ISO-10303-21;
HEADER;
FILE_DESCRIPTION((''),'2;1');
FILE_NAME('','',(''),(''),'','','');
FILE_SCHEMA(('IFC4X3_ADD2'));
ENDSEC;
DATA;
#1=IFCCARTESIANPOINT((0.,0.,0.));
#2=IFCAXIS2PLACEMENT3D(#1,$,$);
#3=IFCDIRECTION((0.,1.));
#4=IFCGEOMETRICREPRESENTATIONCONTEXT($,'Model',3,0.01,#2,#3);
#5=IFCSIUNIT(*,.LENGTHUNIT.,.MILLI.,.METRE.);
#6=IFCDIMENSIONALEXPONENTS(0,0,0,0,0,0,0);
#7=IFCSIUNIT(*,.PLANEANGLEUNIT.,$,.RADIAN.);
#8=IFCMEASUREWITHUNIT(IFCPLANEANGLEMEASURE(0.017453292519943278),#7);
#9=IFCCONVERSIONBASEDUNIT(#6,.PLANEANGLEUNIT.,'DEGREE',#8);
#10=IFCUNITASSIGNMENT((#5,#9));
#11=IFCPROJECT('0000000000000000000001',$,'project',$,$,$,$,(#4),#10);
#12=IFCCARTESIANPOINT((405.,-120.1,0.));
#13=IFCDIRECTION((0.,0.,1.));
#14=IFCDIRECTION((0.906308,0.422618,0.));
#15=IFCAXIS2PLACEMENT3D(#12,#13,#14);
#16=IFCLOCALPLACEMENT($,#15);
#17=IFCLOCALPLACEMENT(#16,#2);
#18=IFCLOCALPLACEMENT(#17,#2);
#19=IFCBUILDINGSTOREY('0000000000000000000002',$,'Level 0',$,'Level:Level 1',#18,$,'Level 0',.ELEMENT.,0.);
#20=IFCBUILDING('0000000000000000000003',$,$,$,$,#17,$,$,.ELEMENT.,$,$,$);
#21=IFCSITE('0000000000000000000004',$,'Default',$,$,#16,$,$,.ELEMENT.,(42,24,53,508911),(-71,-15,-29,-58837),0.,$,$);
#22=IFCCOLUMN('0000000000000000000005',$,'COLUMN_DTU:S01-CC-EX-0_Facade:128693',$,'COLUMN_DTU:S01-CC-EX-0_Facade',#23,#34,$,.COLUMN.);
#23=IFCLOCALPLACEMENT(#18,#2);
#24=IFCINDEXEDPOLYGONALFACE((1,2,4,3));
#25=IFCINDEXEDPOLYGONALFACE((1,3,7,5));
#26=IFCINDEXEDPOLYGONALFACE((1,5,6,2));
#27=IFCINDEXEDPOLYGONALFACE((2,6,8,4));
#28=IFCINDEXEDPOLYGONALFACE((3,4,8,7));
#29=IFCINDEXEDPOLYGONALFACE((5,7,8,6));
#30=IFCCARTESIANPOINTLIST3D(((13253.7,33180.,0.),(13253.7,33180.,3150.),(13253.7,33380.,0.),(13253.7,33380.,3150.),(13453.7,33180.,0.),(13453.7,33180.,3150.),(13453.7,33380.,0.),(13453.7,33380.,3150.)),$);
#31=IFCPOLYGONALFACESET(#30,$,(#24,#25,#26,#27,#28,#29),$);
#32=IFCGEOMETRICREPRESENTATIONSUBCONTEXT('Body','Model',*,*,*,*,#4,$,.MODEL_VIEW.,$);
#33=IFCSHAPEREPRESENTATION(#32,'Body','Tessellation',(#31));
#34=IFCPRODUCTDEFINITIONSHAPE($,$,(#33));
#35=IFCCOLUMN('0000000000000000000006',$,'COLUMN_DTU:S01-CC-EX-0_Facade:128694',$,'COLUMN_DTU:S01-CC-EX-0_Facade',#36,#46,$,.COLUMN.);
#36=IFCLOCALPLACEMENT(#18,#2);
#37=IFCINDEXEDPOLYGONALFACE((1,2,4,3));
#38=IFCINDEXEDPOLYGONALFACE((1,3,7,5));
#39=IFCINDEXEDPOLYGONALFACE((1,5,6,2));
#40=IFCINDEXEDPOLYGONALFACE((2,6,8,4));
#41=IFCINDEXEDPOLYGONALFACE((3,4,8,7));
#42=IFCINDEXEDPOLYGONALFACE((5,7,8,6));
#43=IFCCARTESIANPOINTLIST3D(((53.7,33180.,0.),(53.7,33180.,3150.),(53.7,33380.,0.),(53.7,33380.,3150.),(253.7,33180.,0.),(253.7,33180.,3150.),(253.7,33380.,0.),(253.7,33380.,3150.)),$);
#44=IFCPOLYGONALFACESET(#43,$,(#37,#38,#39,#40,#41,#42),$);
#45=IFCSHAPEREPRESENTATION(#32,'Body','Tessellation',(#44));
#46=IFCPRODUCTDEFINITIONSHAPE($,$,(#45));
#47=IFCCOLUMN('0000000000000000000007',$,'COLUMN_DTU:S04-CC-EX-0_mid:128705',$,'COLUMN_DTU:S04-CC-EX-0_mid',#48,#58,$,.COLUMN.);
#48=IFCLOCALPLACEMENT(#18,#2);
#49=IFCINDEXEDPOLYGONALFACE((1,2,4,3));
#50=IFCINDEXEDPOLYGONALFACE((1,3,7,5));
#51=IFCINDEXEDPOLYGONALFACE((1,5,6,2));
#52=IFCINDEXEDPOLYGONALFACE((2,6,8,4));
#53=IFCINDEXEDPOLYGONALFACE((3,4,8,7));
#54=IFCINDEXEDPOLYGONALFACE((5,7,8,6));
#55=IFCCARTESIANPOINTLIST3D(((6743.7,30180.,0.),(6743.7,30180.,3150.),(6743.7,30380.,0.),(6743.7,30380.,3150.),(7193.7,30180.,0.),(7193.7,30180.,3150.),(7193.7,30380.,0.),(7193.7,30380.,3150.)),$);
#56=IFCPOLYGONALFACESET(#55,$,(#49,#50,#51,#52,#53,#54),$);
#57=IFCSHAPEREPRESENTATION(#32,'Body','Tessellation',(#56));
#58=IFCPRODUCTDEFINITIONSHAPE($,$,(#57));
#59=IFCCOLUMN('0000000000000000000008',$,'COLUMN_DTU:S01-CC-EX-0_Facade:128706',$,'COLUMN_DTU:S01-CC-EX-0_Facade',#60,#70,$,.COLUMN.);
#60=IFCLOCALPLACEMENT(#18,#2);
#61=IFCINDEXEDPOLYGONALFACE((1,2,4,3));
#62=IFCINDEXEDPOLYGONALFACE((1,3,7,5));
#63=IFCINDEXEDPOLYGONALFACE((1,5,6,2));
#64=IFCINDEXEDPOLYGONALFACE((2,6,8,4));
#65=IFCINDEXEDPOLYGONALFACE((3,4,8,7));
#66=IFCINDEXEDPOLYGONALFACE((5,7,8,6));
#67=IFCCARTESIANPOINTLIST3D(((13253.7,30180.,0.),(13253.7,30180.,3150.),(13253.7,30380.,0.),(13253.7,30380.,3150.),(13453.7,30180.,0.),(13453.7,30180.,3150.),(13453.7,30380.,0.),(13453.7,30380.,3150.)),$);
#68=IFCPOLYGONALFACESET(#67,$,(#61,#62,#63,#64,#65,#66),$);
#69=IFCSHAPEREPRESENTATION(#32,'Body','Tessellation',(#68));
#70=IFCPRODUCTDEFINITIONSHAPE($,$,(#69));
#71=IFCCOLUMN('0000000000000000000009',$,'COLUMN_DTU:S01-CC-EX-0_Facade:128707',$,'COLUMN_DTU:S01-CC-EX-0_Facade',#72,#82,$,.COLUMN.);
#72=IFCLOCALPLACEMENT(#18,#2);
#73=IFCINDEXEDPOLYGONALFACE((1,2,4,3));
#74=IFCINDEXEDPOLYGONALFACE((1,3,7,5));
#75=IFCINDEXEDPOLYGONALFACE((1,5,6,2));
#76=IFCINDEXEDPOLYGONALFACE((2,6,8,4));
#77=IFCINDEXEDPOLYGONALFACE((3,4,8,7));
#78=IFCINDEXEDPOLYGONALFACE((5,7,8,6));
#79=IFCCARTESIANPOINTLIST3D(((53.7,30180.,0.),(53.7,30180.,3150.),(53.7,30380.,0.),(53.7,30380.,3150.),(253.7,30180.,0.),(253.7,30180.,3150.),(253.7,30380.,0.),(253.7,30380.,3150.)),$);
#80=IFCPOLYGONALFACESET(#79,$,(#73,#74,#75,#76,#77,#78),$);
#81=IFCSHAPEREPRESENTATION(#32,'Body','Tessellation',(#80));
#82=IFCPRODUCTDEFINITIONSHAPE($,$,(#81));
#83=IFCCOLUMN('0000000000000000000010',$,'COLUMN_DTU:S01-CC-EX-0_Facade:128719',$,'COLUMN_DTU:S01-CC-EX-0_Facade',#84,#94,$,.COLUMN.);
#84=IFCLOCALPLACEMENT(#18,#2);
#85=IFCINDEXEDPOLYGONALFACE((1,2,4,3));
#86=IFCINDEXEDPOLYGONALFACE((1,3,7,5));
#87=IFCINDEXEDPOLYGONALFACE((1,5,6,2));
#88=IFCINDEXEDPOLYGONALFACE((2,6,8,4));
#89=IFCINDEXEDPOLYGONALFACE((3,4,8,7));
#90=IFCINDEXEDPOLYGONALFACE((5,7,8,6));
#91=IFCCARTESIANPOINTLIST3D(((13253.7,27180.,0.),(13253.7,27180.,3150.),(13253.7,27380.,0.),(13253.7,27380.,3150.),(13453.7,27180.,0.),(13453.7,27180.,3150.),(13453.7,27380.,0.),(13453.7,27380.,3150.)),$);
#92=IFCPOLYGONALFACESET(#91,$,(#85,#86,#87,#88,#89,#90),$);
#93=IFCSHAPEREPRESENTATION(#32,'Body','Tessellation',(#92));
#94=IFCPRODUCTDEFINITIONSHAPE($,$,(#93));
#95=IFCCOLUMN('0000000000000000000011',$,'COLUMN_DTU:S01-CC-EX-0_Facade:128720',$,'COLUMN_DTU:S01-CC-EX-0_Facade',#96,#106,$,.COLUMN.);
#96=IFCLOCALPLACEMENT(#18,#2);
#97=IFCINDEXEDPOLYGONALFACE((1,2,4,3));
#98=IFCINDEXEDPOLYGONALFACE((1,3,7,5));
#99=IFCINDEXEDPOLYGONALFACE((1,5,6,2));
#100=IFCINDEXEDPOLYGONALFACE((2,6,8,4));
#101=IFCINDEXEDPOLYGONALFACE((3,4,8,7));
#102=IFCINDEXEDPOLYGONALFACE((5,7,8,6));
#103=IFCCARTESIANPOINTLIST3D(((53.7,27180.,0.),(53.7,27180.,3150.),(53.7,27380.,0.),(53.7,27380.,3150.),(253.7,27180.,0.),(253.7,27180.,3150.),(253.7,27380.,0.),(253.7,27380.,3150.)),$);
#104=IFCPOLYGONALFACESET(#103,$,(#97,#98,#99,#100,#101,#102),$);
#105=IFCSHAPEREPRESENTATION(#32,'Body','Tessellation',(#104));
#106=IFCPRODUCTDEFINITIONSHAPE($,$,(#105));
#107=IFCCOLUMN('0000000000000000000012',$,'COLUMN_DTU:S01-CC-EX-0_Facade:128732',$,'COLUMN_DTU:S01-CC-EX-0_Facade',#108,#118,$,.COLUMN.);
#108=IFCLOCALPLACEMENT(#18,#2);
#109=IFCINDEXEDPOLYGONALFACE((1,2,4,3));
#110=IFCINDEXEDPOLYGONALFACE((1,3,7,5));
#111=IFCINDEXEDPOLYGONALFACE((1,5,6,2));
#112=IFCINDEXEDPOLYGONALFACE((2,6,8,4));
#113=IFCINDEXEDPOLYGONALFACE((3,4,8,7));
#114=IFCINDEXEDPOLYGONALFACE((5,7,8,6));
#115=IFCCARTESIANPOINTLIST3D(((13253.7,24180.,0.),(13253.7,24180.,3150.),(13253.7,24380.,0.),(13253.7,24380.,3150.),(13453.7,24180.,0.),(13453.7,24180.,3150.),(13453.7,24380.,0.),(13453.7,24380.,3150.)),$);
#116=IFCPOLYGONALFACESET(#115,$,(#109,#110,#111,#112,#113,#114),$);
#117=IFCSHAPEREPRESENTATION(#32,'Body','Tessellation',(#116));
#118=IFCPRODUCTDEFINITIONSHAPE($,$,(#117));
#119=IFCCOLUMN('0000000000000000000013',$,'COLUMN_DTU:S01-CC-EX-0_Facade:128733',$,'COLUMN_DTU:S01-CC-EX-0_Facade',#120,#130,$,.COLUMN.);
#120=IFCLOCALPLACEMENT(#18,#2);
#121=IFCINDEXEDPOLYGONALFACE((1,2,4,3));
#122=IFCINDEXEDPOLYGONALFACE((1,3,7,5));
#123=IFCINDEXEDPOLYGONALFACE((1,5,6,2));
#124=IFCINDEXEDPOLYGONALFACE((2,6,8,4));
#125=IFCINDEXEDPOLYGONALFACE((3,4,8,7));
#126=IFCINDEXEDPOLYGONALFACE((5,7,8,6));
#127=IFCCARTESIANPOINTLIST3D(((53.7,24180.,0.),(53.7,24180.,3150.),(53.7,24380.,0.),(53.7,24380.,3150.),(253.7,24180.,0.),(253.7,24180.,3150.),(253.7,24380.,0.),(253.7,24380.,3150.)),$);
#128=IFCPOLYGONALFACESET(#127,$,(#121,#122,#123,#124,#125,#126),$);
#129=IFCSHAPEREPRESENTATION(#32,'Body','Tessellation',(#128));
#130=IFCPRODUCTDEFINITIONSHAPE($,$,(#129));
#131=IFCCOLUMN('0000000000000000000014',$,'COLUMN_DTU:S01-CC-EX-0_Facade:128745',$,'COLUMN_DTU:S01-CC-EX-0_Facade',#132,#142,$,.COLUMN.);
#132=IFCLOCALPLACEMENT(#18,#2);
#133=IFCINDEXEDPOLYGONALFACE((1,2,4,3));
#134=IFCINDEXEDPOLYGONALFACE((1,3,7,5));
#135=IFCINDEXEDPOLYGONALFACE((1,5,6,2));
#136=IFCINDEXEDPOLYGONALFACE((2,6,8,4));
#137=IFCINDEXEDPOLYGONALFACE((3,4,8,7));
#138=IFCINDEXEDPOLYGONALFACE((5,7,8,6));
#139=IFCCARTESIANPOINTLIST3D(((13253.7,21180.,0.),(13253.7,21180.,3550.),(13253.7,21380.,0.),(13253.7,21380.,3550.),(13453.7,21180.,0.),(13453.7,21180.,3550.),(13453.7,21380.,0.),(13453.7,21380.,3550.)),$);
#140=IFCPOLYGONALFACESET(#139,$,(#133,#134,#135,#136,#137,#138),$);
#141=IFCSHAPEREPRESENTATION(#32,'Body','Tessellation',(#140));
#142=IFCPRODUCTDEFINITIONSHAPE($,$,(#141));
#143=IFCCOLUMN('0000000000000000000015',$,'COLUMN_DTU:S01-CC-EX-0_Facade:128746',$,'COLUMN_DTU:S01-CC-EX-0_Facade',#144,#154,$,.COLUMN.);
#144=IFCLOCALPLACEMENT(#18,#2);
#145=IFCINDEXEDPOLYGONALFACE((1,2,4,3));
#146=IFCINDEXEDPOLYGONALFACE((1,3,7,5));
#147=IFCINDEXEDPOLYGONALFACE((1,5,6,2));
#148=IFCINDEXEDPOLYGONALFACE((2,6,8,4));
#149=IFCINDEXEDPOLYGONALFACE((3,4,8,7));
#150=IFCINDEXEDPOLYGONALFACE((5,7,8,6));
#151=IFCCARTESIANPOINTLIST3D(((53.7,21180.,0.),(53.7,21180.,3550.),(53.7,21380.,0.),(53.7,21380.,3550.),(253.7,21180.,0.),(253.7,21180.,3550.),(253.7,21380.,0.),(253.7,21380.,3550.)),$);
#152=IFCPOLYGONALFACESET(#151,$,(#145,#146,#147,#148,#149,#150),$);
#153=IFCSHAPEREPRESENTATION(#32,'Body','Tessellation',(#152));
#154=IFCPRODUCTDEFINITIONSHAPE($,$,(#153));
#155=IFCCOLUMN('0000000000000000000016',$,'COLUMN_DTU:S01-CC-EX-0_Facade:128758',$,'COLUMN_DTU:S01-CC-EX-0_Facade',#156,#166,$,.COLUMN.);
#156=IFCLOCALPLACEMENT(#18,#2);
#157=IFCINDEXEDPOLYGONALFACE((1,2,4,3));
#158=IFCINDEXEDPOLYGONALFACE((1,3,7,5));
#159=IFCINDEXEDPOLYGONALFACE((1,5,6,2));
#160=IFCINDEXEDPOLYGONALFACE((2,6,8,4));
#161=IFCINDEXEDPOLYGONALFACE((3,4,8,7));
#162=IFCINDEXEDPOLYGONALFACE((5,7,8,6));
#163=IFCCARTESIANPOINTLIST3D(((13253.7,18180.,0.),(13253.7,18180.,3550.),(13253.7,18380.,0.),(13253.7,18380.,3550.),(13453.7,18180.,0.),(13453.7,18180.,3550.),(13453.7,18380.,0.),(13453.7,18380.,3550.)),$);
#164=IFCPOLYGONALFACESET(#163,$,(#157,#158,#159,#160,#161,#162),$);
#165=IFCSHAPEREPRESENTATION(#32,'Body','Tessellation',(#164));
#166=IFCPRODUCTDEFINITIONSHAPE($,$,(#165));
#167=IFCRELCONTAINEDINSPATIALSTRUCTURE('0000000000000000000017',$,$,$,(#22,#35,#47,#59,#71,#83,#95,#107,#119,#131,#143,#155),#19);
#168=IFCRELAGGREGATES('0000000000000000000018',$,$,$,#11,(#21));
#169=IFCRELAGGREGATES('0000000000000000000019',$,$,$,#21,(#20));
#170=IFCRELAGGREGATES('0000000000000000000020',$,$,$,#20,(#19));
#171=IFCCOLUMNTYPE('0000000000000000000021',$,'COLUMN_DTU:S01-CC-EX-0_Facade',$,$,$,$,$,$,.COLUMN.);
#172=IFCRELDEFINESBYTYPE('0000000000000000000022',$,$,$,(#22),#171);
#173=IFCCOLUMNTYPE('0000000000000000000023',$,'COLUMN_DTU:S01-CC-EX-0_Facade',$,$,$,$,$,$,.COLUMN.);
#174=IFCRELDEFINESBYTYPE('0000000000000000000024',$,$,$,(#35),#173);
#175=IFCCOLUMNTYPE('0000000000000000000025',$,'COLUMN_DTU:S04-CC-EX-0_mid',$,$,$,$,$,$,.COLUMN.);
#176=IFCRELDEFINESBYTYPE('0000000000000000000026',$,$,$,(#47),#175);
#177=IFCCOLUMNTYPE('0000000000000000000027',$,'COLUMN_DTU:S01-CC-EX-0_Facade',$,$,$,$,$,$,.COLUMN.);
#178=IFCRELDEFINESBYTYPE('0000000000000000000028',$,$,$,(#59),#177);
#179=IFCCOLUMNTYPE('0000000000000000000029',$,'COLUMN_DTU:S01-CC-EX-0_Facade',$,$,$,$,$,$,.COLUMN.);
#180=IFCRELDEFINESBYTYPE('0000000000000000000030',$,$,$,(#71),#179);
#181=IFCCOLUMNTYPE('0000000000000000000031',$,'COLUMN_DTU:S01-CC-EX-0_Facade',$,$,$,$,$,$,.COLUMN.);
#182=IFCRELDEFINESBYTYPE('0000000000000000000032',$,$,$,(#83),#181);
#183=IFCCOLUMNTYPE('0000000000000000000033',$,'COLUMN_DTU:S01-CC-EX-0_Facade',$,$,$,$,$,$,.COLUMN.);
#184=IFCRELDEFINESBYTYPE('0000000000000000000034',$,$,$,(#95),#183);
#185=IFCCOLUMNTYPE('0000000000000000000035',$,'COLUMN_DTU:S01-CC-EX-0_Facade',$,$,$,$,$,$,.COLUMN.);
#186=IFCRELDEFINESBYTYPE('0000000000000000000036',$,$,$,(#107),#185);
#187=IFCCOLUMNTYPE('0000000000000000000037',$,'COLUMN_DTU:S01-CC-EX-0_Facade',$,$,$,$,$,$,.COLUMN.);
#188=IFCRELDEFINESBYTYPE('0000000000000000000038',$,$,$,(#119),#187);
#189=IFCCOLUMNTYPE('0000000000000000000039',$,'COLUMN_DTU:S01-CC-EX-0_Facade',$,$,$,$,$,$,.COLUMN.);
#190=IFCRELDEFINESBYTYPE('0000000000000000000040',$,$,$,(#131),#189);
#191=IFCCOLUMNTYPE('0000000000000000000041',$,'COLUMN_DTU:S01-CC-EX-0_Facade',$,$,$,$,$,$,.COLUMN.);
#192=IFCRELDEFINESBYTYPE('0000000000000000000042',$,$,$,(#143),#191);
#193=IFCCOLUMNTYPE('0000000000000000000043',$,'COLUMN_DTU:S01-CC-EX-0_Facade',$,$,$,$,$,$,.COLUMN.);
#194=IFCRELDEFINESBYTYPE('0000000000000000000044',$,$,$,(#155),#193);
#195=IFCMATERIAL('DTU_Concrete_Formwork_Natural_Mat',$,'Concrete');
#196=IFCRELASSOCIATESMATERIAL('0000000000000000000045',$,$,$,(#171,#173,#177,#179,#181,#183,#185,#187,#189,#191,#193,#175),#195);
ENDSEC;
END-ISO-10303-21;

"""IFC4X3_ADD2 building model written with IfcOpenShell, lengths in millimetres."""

from ifc_helpers import new_model, entity, si_unit, converted_unit, direction, frame, frame_2d, origin, place, context, subcontext, project, spatial, rectangle, extrude, source, transform, mapped, material, material_profile, profile_set, type_object, type_shapes, element, save


model = new_model("IFC4X3_ADD2")

# Units and contexts
model_context = context("Model", 3, precision=0.01, world=origin(), true_north=direction((0.0, 1.0)))
body_context = subcontext(model_context, "Body", "Model", "MODEL_VIEW")
ifc_project = project(units=[si_unit("LENGTHUNIT", "METRE", prefix="MILLI"), converted_unit("PLANEANGLEUNIT", "DEGREE", entity("IfcPlaneAngleMeasure", 0.017453292519943278), si_unit("PLANEANGLEUNIT", "RADIAN"), dimensions=[0, 0, 0, 0, 0, 0, 0])], contexts=[model_context])

# Site, building, storey
site_placement = place(None, frame((405.0, -120.1, 0.0), z_axis=(0.0, 0.0, 1.0), x_axis=(0.906308, 0.422618, 0.0)))
site = spatial("IfcSite", under=ifc_project, at=site_placement, Name="Default", CompositionType="ELEMENT", RefLatitude=(42, 24, 53, 508911), RefLongitude=(-71, -15, -29, -58837), RefElevation=0.0)
building_placement = place(site_placement, origin())
building = spatial("IfcBuilding", under=site, at=building_placement, CompositionType="ELEMENT")
storey_placement = place(building_placement, origin())
storey = spatial("IfcBuildingStorey", under=building, at=storey_placement, Name="Level 0", ObjectType="Level:Level 1", LongName="Level 0", CompositionType="ELEMENT", Elevation=0.0)

# Columns
ifc_material = material(Name="DTU_Concrete_Formwork_Natural_Mat", Category="Concrete")
ifc_material_profile_1 = material_profile(ifc_material, rectangle(XDim=200.0, YDim=200.0, at=frame_2d((0.0, 0.0), x_axis=(1.0, 0.0))), Name="S01-CC-EX-0_Facade")
ifc_profile_set_1 = profile_set([ifc_material_profile_1], Name="S01-CC-EX-0_Facade")
ifc_material_profile_2 = material_profile(ifc_material, rectangle(XDim=200.0, YDim=450.0, at=frame_2d((0.0, 0.0), x_axis=(1.0, 0.0))), Name="S04-CC-EX-0_mid")
ifc_profile_set_2 = profile_set([ifc_material_profile_2], Name="S04-CC-EX-0_mid")
column_type_1 = type_object("IfcColumnType", Name="COLUMN_DTU:S01-CC-EX-0_Facade", PredefinedType="COLUMN", material=ifc_profile_set_1)
shared_shape_1 = source(origin(), body_context, "Body", "SweptSolid", [
    extrude(rectangle(XDim=200.0, YDim=200.0, at=frame_2d((0.0, 0.0), x_axis=(1.0, 0.0))), frame((13353.7, 33280.0, 0.0), z_axis=(0.0, 0.0, 1.0), x_axis=(0.0, 1.0, 0.0)), (0.0, 0.0, 1.0), 3150.0),
])
type_shapes(column_type_1, [shared_shape_1])
column_1_placement = place(storey_placement, origin())
element("IfcColumn", 1, at=column_1_placement, inside=storey, type_object=column_type_1, Name="COLUMN_DTU:S01-CC-EX-0_Facade:128693", ObjectType="COLUMN_DTU:S01-CC-EX-0_Facade", PredefinedType="COLUMN", context=body_context, shape_type="MappedRepresentation", body=[
    mapped(shared_shape_1, transform((0.0, 0.0, 0.0), scale=1.0)),
])
column_type_2 = type_object("IfcColumnType", Name="COLUMN_DTU:S01-CC-EX-0_Facade", PredefinedType="COLUMN", material=ifc_profile_set_1)
shared_shape_2 = source(origin(), body_context, "Body", "SweptSolid", [
    extrude(rectangle(XDim=200.0, YDim=200.0, at=frame_2d((0.0, 0.0), x_axis=(1.0, 0.0))), frame((153.7, 33280.0, 0.0), z_axis=(0.0, 0.0, 1.0), x_axis=(0.0, 1.0, 0.0)), (0.0, 0.0, 1.0), 3150.0),
])
type_shapes(column_type_2, [shared_shape_2])
column_2_placement = place(storey_placement, origin())
element("IfcColumn", 2, at=column_2_placement, inside=storey, type_object=column_type_2, Name="COLUMN_DTU:S01-CC-EX-0_Facade:128694", ObjectType="COLUMN_DTU:S01-CC-EX-0_Facade", PredefinedType="COLUMN", context=body_context, shape_type="MappedRepresentation", body=[
    mapped(shared_shape_2, transform((0.0, 0.0, 0.0), scale=1.0)),
])
column_type_3 = type_object("IfcColumnType", Name="COLUMN_DTU:S04-CC-EX-0_mid", PredefinedType="COLUMN", material=ifc_profile_set_2)
shared_shape_3 = source(origin(), body_context, "Body", "SweptSolid", [
    extrude(rectangle(XDim=200.0, YDim=450.0, at=frame_2d((0.0, 0.0), x_axis=(1.0, 0.0))), frame((6968.7, 30280.0, 0.0), z_axis=(0.0, 0.0, 1.0), x_axis=(0.0, 1.0, 0.0)), (0.0, 0.0, 1.0), 3150.0),
])
type_shapes(column_type_3, [shared_shape_3])
column_3_placement = place(storey_placement, origin())
element("IfcColumn", 3, at=column_3_placement, inside=storey, type_object=column_type_3, Name="COLUMN_DTU:S04-CC-EX-0_mid:128705", ObjectType="COLUMN_DTU:S04-CC-EX-0_mid", PredefinedType="COLUMN", context=body_context, shape_type="MappedRepresentation", body=[
    mapped(shared_shape_3, transform((0.0, 0.0, 0.0), scale=1.0)),
])
column_type_4 = type_object("IfcColumnType", Name="COLUMN_DTU:S01-CC-EX-0_Facade", PredefinedType="COLUMN", material=ifc_profile_set_1)
shared_shape_4 = source(origin(), body_context, "Body", "SweptSolid", [
    extrude(rectangle(XDim=200.0, YDim=200.0, at=frame_2d((0.0, 0.0), x_axis=(1.0, 0.0))), frame((13353.7, 30280.0, 0.0), z_axis=(0.0, 0.0, 1.0), x_axis=(0.0, 1.0, 0.0)), (0.0, 0.0, 1.0), 3150.0),
])
type_shapes(column_type_4, [shared_shape_4])
column_4_placement = place(storey_placement, origin())
element("IfcColumn", 4, at=column_4_placement, inside=storey, type_object=column_type_4, Name="COLUMN_DTU:S01-CC-EX-0_Facade:128706", ObjectType="COLUMN_DTU:S01-CC-EX-0_Facade", PredefinedType="COLUMN", context=body_context, shape_type="MappedRepresentation", body=[
    mapped(shared_shape_4, transform((0.0, 0.0, 0.0), scale=1.0)),
])
column_type_5 = type_object("IfcColumnType", Name="COLUMN_DTU:S01-CC-EX-0_Facade", PredefinedType="COLUMN", material=ifc_profile_set_1)
shared_shape_5 = source(origin(), body_context, "Body", "SweptSolid", [
    extrude(rectangle(XDim=200.0, YDim=200.0, at=frame_2d((0.0, 0.0), x_axis=(1.0, 0.0))), frame((153.7, 30280.0, 0.0), z_axis=(0.0, 0.0, 1.0), x_axis=(0.0, 1.0, 0.0)), (0.0, 0.0, 1.0), 3150.0),
])
type_shapes(column_type_5, [shared_shape_5])
column_5_placement = place(storey_placement, origin())
element("IfcColumn", 5, at=column_5_placement, inside=storey, type_object=column_type_5, Name="COLUMN_DTU:S01-CC-EX-0_Facade:128707", ObjectType="COLUMN_DTU:S01-CC-EX-0_Facade", PredefinedType="COLUMN", context=body_context, shape_type="MappedRepresentation", body=[
    mapped(shared_shape_5, transform((0.0, 0.0, 0.0), scale=1.0)),
])
column_type_6 = type_object("IfcColumnType", Name="COLUMN_DTU:S01-CC-EX-0_Facade", PredefinedType="COLUMN", material=ifc_profile_set_1)
shared_shape_6 = source(origin(), body_context, "Body", "SweptSolid", [
    extrude(rectangle(XDim=200.0, YDim=200.0, at=frame_2d((0.0, 0.0), x_axis=(1.0, 0.0))), frame((13353.7, 27280.0, 0.0), z_axis=(0.0, 0.0, 1.0), x_axis=(0.0, 1.0, 0.0)), (0.0, 0.0, 1.0), 3150.0),
])
type_shapes(column_type_6, [shared_shape_6])
column_6_placement = place(storey_placement, origin())
element("IfcColumn", 6, at=column_6_placement, inside=storey, type_object=column_type_6, Name="COLUMN_DTU:S01-CC-EX-0_Facade:128719", ObjectType="COLUMN_DTU:S01-CC-EX-0_Facade", PredefinedType="COLUMN", context=body_context, shape_type="MappedRepresentation", body=[
    mapped(shared_shape_6, transform((0.0, 0.0, 0.0), scale=1.0)),
])
column_type_7 = type_object("IfcColumnType", Name="COLUMN_DTU:S01-CC-EX-0_Facade", PredefinedType="COLUMN", material=ifc_profile_set_1)
shared_shape_7 = source(origin(), body_context, "Body", "SweptSolid", [
    extrude(rectangle(XDim=200.0, YDim=200.0, at=frame_2d((0.0, 0.0), x_axis=(1.0, 0.0))), frame((153.7, 27280.0, 0.0), z_axis=(0.0, 0.0, 1.0), x_axis=(0.0, 1.0, 0.0)), (0.0, 0.0, 1.0), 3150.0),
])
type_shapes(column_type_7, [shared_shape_7])
column_7_placement = place(storey_placement, origin())
element("IfcColumn", 7, at=column_7_placement, inside=storey, type_object=column_type_7, Name="COLUMN_DTU:S01-CC-EX-0_Facade:128720", ObjectType="COLUMN_DTU:S01-CC-EX-0_Facade", PredefinedType="COLUMN", context=body_context, shape_type="MappedRepresentation", body=[
    mapped(shared_shape_7, transform((0.0, 0.0, 0.0), scale=1.0)),
])
column_type_8 = type_object("IfcColumnType", Name="COLUMN_DTU:S01-CC-EX-0_Facade", PredefinedType="COLUMN", material=ifc_profile_set_1)
shared_shape_8 = source(origin(), body_context, "Body", "SweptSolid", [
    extrude(rectangle(XDim=200.0, YDim=200.0, at=frame_2d((0.0, 0.0), x_axis=(1.0, 0.0))), frame((13353.7, 24280.0, 0.0), z_axis=(0.0, 0.0, 1.0), x_axis=(0.0, 1.0, 0.0)), (0.0, 0.0, 1.0), 3150.0),
])
type_shapes(column_type_8, [shared_shape_8])
column_8_placement = place(storey_placement, origin())
element("IfcColumn", 8, at=column_8_placement, inside=storey, type_object=column_type_8, Name="COLUMN_DTU:S01-CC-EX-0_Facade:128732", ObjectType="COLUMN_DTU:S01-CC-EX-0_Facade", PredefinedType="COLUMN", context=body_context, shape_type="MappedRepresentation", body=[
    mapped(shared_shape_8, transform((0.0, 0.0, 0.0), scale=1.0)),
])
column_type_9 = type_object("IfcColumnType", Name="COLUMN_DTU:S01-CC-EX-0_Facade", PredefinedType="COLUMN", material=ifc_profile_set_1)
shared_shape_9 = source(origin(), body_context, "Body", "SweptSolid", [
    extrude(rectangle(XDim=200.0, YDim=200.0, at=frame_2d((0.0, 0.0), x_axis=(1.0, 0.0))), frame((153.7, 24280.0, 0.0), z_axis=(0.0, 0.0, 1.0), x_axis=(0.0, 1.0, 0.0)), (0.0, 0.0, 1.0), 3150.0),
])
type_shapes(column_type_9, [shared_shape_9])
column_9_placement = place(storey_placement, origin())
element("IfcColumn", 9, at=column_9_placement, inside=storey, type_object=column_type_9, Name="COLUMN_DTU:S01-CC-EX-0_Facade:128733", ObjectType="COLUMN_DTU:S01-CC-EX-0_Facade", PredefinedType="COLUMN", context=body_context, shape_type="MappedRepresentation", body=[
    mapped(shared_shape_9, transform((0.0, 0.0, 0.0), scale=1.0)),
])
column_type_10 = type_object("IfcColumnType", Name="COLUMN_DTU:S01-CC-EX-0_Facade", PredefinedType="COLUMN", material=ifc_profile_set_1)
shared_shape_10 = source(origin(), body_context, "Body", "SweptSolid", [
    extrude(rectangle(XDim=200.0, YDim=200.0, at=frame_2d((0.0, 0.0), x_axis=(1.0, 0.0))), frame((13353.7, 21280.0, 0.0), z_axis=(0.0, 0.0, 1.0), x_axis=(0.0, 1.0, 0.0)), (0.0, 0.0, 1.0), 3550.0),
])
type_shapes(column_type_10, [shared_shape_10])
column_10_placement = place(storey_placement, origin())
element("IfcColumn", 10, at=column_10_placement, inside=storey, type_object=column_type_10, Name="COLUMN_DTU:S01-CC-EX-0_Facade:128745", ObjectType="COLUMN_DTU:S01-CC-EX-0_Facade", PredefinedType="COLUMN", context=body_context, shape_type="MappedRepresentation", body=[
    mapped(shared_shape_10, transform((0.0, 0.0, 0.0), scale=1.0)),
])
column_type_11 = type_object("IfcColumnType", Name="COLUMN_DTU:S01-CC-EX-0_Facade", PredefinedType="COLUMN", material=ifc_profile_set_1)
shared_shape_11 = source(origin(), body_context, "Body", "SweptSolid", [
    extrude(rectangle(XDim=200.0, YDim=200.0, at=frame_2d((0.0, 0.0), x_axis=(1.0, 0.0))), frame((153.7, 21280.0, 0.0), z_axis=(0.0, 0.0, 1.0), x_axis=(0.0, 1.0, 0.0)), (0.0, 0.0, 1.0), 3550.0),
])
type_shapes(column_type_11, [shared_shape_11])
column_11_placement = place(storey_placement, origin())
element("IfcColumn", 11, at=column_11_placement, inside=storey, type_object=column_type_11, Name="COLUMN_DTU:S01-CC-EX-0_Facade:128746", ObjectType="COLUMN_DTU:S01-CC-EX-0_Facade", PredefinedType="COLUMN", context=body_context, shape_type="MappedRepresentation", body=[
    mapped(shared_shape_11, transform((0.0, 0.0, 0.0), scale=1.0)),
])
column_type_12 = type_object("IfcColumnType", Name="COLUMN_DTU:S01-CC-EX-0_Facade", PredefinedType="COLUMN", material=ifc_profile_set_1)
shared_shape_12 = source(origin(), body_context, "Body", "SweptSolid", [
    extrude(rectangle(XDim=200.0, YDim=200.0, at=frame_2d((0.0, 0.0), x_axis=(1.0, 0.0))), frame((13353.7, 18280.0, 0.0), z_axis=(0.0, 0.0, 1.0), x_axis=(0.0, 1.0, 0.0)), (0.0, 0.0, 1.0), 3550.0),
])
type_shapes(column_type_12, [shared_shape_12])
column_12_placement = place(storey_placement, origin())
element("IfcColumn", 12, at=column_12_placement, inside=storey, type_object=column_type_12, Name="COLUMN_DTU:S01-CC-EX-0_Facade:128758", ObjectType="COLUMN_DTU:S01-CC-EX-0_Facade", PredefinedType="COLUMN", context=body_context, shape_type="MappedRepresentation", body=[
    mapped(shared_shape_12, transform((0.0, 0.0, 0.0), scale=1.0)),
])

save(model, "model.ifc")
